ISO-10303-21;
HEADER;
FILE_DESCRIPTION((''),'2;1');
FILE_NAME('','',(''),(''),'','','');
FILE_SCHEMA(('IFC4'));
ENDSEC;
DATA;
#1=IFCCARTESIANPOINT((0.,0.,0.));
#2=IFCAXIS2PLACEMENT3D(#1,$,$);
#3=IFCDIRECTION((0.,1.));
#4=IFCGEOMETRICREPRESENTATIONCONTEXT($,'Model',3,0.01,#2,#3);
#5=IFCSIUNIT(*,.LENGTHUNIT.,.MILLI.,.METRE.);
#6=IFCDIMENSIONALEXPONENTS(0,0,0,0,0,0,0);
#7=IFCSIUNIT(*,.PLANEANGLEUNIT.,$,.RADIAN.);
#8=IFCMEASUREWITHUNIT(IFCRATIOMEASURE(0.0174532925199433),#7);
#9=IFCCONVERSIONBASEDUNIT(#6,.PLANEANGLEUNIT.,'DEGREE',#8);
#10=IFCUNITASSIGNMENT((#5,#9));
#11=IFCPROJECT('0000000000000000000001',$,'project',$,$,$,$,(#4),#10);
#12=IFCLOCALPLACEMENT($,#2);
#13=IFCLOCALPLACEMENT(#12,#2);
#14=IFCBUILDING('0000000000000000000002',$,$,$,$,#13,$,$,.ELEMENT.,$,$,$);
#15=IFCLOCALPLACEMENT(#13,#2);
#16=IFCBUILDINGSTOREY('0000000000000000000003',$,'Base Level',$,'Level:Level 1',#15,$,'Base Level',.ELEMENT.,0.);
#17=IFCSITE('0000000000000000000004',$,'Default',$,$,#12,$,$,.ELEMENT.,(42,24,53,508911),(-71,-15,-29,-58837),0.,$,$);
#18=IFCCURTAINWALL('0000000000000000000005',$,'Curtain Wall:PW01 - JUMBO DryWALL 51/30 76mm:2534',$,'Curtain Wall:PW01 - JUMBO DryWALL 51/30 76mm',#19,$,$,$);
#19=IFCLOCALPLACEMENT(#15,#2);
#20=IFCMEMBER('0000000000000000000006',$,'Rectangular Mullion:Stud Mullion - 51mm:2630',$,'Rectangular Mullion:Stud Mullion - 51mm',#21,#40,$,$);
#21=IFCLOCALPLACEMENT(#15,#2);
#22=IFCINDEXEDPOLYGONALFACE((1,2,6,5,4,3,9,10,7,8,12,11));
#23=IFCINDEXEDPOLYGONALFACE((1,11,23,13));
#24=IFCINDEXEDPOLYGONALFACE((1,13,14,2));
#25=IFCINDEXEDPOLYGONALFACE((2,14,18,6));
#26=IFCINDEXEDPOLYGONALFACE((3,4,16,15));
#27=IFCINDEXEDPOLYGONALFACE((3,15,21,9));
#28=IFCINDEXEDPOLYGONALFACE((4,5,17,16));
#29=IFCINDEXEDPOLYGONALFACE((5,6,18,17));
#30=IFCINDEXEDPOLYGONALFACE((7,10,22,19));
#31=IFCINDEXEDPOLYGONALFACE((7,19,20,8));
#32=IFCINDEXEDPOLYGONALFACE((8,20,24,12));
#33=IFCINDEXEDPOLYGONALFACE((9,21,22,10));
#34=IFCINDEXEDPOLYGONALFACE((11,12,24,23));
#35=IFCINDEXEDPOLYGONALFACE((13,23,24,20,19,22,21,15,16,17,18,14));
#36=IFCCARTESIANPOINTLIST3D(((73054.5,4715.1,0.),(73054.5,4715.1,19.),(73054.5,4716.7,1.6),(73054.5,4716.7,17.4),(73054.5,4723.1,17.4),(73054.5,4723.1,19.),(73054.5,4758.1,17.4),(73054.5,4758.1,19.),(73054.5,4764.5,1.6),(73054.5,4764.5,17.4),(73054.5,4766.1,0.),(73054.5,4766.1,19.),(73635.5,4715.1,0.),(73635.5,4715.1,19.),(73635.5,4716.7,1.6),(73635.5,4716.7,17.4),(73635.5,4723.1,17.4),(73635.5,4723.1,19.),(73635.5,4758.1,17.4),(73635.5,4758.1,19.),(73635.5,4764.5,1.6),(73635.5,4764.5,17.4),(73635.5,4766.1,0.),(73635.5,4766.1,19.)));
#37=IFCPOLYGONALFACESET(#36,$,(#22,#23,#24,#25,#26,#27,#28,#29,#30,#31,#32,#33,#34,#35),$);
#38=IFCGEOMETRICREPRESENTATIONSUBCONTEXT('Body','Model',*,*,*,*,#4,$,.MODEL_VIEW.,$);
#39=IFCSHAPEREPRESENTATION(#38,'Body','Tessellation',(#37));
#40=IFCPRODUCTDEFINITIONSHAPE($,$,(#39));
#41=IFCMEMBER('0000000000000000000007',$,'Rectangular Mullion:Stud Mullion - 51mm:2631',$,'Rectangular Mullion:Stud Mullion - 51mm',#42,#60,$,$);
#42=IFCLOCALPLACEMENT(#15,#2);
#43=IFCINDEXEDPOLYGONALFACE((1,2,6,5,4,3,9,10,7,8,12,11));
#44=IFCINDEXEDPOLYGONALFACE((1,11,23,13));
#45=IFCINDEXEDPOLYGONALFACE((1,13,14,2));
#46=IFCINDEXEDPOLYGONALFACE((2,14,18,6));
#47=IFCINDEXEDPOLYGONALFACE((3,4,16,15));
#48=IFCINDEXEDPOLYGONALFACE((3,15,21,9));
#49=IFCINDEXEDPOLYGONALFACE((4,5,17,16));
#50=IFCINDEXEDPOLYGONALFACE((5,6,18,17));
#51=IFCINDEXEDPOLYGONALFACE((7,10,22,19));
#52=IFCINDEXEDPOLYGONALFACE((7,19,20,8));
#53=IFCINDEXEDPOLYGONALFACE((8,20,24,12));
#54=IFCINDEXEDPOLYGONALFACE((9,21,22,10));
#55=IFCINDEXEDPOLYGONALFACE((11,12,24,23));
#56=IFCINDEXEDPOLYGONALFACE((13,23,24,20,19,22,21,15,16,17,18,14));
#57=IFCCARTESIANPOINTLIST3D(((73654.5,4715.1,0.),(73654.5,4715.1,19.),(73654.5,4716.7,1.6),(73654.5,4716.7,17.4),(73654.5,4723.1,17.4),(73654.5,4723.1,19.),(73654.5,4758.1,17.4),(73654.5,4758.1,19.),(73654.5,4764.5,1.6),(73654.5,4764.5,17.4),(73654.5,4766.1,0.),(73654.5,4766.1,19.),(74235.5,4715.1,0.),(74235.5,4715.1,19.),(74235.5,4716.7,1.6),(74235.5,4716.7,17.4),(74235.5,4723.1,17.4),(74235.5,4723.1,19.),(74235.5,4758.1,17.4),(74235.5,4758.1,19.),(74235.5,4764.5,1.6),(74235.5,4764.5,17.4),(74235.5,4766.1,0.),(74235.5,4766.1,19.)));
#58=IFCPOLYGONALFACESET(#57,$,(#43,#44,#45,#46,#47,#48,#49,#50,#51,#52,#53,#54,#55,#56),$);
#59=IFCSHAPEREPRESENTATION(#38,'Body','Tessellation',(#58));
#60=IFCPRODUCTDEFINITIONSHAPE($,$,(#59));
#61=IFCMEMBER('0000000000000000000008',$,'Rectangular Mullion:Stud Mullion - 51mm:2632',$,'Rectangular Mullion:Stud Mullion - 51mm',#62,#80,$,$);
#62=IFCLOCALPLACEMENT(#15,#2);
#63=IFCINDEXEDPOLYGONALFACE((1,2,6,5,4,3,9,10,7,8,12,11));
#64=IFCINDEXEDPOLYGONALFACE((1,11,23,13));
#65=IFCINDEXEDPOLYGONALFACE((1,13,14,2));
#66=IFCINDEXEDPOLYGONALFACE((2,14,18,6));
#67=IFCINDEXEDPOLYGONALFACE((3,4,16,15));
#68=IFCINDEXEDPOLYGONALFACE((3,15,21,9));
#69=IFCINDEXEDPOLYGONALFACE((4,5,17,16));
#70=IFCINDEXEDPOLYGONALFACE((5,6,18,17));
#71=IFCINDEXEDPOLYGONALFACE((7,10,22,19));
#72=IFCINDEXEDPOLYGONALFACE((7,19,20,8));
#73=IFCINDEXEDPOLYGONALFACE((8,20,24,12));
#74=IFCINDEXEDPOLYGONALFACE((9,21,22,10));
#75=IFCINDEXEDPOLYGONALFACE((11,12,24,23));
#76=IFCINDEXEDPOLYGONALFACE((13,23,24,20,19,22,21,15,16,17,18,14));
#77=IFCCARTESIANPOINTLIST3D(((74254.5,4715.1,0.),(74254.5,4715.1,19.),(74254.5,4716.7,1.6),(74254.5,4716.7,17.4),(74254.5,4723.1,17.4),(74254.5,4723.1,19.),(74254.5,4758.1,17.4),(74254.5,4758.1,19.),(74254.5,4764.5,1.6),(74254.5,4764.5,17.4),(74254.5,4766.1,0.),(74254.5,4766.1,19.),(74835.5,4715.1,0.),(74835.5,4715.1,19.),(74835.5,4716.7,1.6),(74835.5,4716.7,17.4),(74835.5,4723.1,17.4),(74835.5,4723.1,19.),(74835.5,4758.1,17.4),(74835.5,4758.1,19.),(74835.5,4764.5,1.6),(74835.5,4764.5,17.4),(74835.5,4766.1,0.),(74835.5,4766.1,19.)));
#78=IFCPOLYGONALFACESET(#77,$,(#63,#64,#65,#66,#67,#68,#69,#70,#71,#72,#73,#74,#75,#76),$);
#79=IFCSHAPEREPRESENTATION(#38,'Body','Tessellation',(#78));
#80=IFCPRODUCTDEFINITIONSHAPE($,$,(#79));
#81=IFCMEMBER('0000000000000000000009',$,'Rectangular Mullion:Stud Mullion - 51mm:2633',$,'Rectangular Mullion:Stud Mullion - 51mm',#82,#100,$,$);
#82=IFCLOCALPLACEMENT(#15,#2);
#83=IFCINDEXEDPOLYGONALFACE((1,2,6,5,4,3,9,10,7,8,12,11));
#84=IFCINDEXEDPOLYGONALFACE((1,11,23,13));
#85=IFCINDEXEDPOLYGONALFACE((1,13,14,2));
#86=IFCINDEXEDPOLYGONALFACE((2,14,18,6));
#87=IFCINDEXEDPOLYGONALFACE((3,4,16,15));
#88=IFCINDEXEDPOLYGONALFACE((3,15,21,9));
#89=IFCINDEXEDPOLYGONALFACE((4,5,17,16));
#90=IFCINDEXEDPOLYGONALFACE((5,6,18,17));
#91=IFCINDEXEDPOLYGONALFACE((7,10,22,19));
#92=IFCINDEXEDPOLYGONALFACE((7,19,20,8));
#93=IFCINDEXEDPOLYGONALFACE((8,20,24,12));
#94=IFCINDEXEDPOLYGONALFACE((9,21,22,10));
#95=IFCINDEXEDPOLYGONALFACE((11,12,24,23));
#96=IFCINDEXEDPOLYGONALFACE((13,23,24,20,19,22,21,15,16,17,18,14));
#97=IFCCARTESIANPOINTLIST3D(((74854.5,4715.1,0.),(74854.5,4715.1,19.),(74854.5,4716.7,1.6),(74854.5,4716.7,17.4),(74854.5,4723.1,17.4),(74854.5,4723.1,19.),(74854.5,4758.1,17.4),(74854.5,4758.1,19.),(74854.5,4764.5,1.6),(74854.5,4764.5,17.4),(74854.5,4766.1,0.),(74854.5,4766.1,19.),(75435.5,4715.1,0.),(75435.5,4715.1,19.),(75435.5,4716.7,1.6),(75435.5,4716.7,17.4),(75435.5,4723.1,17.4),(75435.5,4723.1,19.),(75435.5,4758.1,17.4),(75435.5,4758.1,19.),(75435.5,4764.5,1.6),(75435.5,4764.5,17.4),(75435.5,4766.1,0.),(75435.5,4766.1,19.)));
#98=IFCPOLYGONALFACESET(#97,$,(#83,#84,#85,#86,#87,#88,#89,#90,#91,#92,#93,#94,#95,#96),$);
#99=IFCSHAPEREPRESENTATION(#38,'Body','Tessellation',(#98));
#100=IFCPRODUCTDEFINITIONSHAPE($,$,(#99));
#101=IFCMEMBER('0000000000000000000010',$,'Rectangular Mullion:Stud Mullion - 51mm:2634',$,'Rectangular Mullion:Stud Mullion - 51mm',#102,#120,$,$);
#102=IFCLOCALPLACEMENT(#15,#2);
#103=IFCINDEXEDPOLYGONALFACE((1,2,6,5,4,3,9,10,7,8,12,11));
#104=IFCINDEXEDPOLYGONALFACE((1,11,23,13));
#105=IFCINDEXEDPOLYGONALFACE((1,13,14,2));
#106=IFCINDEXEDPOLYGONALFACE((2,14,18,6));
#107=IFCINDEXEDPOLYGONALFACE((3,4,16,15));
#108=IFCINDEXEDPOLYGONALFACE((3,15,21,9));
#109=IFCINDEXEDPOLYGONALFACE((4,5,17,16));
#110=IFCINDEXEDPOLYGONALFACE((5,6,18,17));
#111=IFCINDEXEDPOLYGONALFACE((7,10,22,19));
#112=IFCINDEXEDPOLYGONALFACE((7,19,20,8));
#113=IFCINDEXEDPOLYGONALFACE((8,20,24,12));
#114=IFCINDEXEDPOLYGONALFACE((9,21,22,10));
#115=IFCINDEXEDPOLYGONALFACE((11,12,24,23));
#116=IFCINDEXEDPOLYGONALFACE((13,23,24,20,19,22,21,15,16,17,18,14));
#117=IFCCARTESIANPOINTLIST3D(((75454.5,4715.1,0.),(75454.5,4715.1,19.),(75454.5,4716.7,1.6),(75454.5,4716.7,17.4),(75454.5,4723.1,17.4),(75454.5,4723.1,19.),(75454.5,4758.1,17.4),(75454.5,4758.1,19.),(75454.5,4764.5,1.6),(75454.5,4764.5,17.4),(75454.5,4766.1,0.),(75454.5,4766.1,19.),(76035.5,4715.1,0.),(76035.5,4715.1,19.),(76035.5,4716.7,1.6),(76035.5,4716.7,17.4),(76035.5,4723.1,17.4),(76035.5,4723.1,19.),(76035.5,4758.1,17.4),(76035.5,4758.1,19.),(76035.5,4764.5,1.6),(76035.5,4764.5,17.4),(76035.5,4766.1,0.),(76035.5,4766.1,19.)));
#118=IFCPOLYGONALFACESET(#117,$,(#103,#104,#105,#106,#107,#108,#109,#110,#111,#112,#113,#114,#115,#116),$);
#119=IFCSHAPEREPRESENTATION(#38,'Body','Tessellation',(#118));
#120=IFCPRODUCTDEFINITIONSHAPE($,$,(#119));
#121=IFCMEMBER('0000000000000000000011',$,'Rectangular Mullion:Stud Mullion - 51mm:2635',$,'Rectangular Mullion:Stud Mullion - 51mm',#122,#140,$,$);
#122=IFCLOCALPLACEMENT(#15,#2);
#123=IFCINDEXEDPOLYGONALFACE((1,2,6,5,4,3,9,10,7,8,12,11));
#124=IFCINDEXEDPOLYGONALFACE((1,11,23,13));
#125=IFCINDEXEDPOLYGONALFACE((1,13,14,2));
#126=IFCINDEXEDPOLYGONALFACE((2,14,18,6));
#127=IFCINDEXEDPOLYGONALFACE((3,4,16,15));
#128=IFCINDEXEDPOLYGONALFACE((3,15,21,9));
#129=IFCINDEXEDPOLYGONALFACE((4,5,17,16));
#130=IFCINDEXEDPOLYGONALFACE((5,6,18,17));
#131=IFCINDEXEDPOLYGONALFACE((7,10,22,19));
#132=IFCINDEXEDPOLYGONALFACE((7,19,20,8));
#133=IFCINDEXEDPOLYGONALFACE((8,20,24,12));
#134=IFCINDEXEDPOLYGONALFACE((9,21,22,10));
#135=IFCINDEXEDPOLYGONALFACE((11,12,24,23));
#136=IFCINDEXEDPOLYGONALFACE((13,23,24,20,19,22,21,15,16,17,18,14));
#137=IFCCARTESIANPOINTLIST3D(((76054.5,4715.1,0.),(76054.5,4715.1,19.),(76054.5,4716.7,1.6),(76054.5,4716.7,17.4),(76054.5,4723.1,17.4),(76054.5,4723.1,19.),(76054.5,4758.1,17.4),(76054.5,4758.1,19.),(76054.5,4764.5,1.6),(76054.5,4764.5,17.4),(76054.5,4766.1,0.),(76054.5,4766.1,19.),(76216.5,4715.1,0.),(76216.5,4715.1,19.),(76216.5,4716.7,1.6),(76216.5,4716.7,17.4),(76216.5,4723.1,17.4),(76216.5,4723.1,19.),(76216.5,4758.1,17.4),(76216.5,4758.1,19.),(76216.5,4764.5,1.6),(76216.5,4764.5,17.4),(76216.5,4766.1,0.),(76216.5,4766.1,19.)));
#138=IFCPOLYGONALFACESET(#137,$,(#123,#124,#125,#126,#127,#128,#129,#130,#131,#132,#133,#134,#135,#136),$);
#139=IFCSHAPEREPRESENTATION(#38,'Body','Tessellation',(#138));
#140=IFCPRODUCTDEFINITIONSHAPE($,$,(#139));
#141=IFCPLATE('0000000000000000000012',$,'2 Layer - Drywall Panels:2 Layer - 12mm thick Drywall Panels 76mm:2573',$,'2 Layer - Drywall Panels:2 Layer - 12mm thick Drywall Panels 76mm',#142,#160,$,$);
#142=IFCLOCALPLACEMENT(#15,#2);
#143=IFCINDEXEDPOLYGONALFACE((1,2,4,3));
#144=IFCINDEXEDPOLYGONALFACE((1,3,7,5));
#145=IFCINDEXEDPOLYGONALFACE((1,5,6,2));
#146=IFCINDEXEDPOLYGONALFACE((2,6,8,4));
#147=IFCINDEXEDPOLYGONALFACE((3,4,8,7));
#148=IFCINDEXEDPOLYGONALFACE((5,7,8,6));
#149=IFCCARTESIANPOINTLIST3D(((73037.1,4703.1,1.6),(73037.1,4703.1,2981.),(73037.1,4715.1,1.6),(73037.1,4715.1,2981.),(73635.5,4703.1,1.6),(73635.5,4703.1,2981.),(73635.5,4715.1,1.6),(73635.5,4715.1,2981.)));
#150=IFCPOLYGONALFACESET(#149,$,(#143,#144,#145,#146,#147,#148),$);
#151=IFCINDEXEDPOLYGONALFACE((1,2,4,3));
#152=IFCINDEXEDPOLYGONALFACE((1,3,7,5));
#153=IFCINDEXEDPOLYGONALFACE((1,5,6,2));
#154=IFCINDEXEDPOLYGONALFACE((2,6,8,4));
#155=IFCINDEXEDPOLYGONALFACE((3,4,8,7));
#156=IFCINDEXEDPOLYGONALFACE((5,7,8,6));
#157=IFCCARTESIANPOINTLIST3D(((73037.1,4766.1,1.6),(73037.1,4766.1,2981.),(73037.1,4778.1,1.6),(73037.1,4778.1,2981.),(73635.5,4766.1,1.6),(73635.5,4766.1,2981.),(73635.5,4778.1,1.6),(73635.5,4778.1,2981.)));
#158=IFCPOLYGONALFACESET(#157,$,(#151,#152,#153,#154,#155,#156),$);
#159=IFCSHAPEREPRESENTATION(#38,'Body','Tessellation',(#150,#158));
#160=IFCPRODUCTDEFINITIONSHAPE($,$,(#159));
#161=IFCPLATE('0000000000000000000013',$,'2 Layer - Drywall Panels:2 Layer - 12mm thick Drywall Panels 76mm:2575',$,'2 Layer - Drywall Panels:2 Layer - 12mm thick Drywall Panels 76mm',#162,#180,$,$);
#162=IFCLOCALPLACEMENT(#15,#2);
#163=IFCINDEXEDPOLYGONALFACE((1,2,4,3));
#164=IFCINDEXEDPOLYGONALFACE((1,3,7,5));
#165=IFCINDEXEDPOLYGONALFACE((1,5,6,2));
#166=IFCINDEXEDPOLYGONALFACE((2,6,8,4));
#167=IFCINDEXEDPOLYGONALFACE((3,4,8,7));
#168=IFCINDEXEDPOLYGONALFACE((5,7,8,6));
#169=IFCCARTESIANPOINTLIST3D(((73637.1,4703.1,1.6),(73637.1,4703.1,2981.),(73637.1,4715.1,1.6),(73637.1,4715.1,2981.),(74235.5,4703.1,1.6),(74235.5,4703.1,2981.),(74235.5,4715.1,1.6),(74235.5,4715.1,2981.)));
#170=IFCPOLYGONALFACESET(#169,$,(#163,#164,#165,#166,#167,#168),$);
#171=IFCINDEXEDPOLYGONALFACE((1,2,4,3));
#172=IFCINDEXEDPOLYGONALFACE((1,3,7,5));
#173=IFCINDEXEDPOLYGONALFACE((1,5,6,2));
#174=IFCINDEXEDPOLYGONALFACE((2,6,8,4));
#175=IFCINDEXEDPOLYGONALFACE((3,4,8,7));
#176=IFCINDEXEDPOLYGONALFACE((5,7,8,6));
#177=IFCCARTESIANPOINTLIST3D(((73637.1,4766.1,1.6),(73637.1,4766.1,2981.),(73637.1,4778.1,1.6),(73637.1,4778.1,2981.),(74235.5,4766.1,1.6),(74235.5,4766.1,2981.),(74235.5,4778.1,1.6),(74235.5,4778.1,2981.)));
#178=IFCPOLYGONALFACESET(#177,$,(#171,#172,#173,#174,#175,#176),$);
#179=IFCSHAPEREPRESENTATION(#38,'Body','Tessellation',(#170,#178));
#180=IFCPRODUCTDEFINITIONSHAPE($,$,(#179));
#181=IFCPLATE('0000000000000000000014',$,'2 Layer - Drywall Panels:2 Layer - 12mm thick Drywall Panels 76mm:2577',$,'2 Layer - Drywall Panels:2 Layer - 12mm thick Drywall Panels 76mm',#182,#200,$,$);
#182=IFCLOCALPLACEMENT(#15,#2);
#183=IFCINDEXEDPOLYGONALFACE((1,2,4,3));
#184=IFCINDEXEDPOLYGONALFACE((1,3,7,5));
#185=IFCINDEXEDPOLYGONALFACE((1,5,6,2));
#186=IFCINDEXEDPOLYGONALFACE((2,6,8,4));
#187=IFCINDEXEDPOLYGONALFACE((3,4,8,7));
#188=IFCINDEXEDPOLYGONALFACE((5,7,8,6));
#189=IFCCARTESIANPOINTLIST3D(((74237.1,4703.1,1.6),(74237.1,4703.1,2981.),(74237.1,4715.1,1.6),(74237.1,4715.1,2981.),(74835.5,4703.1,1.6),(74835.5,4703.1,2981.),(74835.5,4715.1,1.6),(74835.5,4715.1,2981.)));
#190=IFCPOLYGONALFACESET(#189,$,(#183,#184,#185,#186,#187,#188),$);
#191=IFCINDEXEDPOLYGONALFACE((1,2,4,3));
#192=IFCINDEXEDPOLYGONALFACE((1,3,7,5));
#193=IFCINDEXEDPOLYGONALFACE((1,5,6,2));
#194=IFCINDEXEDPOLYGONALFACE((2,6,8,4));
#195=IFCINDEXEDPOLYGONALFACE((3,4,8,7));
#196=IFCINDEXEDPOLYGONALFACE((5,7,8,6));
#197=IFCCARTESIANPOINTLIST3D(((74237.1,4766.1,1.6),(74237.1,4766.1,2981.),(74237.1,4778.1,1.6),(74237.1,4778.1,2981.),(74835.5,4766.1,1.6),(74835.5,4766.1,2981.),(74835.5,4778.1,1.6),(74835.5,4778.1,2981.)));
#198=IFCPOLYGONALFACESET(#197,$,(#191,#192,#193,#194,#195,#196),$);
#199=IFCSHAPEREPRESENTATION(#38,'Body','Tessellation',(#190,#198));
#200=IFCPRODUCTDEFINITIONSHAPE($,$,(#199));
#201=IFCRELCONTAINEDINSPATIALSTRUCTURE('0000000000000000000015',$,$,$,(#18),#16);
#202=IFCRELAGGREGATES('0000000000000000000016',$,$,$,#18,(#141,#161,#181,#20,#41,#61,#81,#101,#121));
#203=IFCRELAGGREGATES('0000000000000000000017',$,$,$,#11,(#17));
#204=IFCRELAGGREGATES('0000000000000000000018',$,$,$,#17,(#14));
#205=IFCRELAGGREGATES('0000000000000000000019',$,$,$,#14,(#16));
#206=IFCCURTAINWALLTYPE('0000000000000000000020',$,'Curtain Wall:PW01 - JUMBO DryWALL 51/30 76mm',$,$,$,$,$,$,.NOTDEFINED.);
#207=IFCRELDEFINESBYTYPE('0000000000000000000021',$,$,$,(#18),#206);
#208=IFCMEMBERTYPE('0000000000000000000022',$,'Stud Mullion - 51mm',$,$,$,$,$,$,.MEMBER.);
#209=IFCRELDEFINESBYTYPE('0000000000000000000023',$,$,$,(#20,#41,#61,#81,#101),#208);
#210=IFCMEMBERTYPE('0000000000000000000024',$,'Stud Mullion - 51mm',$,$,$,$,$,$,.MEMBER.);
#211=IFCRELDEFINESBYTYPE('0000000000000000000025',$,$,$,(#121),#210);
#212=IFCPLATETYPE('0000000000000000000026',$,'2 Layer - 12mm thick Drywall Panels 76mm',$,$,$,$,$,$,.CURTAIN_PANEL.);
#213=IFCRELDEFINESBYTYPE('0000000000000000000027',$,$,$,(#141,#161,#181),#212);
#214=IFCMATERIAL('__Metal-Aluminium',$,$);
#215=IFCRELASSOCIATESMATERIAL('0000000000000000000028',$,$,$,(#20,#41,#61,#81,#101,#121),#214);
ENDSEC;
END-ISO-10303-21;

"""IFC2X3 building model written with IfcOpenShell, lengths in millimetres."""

from ifc_helpers import new_model, entity, si_unit, converted_unit, direction, frame, frame_2d, origin, origin_2d_with_axis, place, context, subcontext, project, spatial, polyline, rectangle, outline, extrude, source, transform, mapped, material, type_object, type_shapes, element, aggregate, save


model = new_model("IFC2X3")

# Units and contexts
model_context = context("Model", 3, precision=0.01, world=origin(), true_north=direction((0.0, 1.0)))
body_context = subcontext(model_context, "Body", "Model", "MODEL_VIEW")
ifc_project = project(units=[si_unit("LENGTHUNIT", "METRE", prefix="MILLI"), converted_unit("PLANEANGLEUNIT", "DEGREE", entity("IfcRatioMeasure", 0.0174532925199433), si_unit("PLANEANGLEUNIT", "RADIAN"), dimensions=[0, 0, 0, 0, 0, 0, 0])], contexts=[model_context])

# Site, building, storey
site_placement = place(None, origin())
site = spatial("IfcSite", under=ifc_project, at=site_placement, Name="Default", CompositionType="ELEMENT", RefLatitude=(42, 24, 53, 508911), RefLongitude=(-71, -15, -29, -58837), RefElevation=0.0)
building_placement = place(site_placement, origin())
building = spatial("IfcBuilding", under=site, at=building_placement, CompositionType="ELEMENT")
storey_placement = place(building_placement, origin())
storey = spatial("IfcBuildingStorey", under=building, at=storey_placement, Name="Base Level", ObjectType="Level:Level 1", LongName="Base Level", CompositionType="ELEMENT", Elevation=0.0)

# Curtain wall, members, plates
curtain_wall_type = type_object("IfcCurtainWallType", Name="Curtain Wall:PW01 - JUMBO DryWALL 51/30 76mm", PredefinedType="NOTDEFINED")
curtain_wall_placement = place(building_placement, origin())
curtain_wall = element("IfcCurtainWall", 1, at=curtain_wall_placement, inside=storey, type_object=curtain_wall_type, Name="Curtain Wall:PW01 - JUMBO DryWALL 51/30 76mm:2534", ObjectType="Curtain Wall:PW01 - JUMBO DryWALL 51/30 76mm")
ifc_material = material(Name="__Metal-Aluminium")
member_type_1 = type_object("IfcMemberType", Name="Stud Mullion - 51mm", PredefinedType="MEMBER")
shared_shape_1 = source(origin(), body_context, "Body", "SweptSolid", [
    extrude(outline(polyline([(17.5, -6.6), (25.5, -6.6), (25.5, 12.4), (-25.5, 12.4), (-25.5, -6.6), (-17.5, -6.6), (-17.5, -5.0), (-23.9, -5.0), (-23.9, 10.8), (23.9, 10.8), (23.9, -5.0), (17.5, -5.0), (17.5, -6.6)])), frame((-12.4, 0.0, -581.0), z_axis=(0.0, 0.0, 1.0), x_axis=(0.0, -1.0, 0.0)), (0.0, 0.0, 1.0), 581.0),
])
type_shapes(member_type_1, [shared_shape_1])
member_1_placement = place(building_placement, frame((73054.5, 4740.6, 0.0), z_axis=(-1.0, 0.0, 0.0), x_axis=(0.0, 0.0, -1.0)))
member_1 = element("IfcMember", 2, at=member_1_placement, type_object=member_type_1, material=ifc_material, Name="Rectangular Mullion:Stud Mullion - 51mm:2630", ObjectType="Rectangular Mullion:Stud Mullion - 51mm", context=body_context, shape_type="MappedRepresentation", body=[
    mapped(shared_shape_1, transform((0.0, 0.0, 0.0), scale=1.0)),
])
member_2_placement = place(building_placement, frame((73654.5, 4740.6, 0.0), z_axis=(-1.0, 0.0, 0.0), x_axis=(0.0, 0.0, -1.0)))
member_2 = element("IfcMember", 3, at=member_2_placement, type_object=member_type_1, material=ifc_material, Name="Rectangular Mullion:Stud Mullion - 51mm:2631", ObjectType="Rectangular Mullion:Stud Mullion - 51mm", context=body_context, shape_type="MappedRepresentation", body=[
    mapped(shared_shape_1, transform((0.0, 0.0, 0.0), scale=1.0)),
])
member_3_placement = place(building_placement, frame((74254.5, 4740.6, 0.0), z_axis=(-1.0, 0.0, 0.0), x_axis=(0.0, 0.0, -1.0)))
member_3 = element("IfcMember", 4, at=member_3_placement, type_object=member_type_1, material=ifc_material, Name="Rectangular Mullion:Stud Mullion - 51mm:2632", ObjectType="Rectangular Mullion:Stud Mullion - 51mm", context=body_context, shape_type="MappedRepresentation", body=[
    mapped(shared_shape_1, transform((0.0, 0.0, 0.0), scale=1.0)),
])
member_4_placement = place(building_placement, frame((74854.5, 4740.6, 0.0), z_axis=(-1.0, 0.0, 0.0), x_axis=(0.0, 0.0, -1.0)))
member_4 = element("IfcMember", 5, at=member_4_placement, type_object=member_type_1, material=ifc_material, Name="Rectangular Mullion:Stud Mullion - 51mm:2633", ObjectType="Rectangular Mullion:Stud Mullion - 51mm", context=body_context, shape_type="MappedRepresentation", body=[
    mapped(shared_shape_1, transform((0.0, 0.0, 0.0), scale=1.0)),
])
member_5_placement = place(building_placement, frame((75454.5, 4740.6, 0.0), z_axis=(-1.0, 0.0, 0.0), x_axis=(0.0, 0.0, -1.0)))
member_5 = element("IfcMember", 6, at=member_5_placement, type_object=member_type_1, material=ifc_material, Name="Rectangular Mullion:Stud Mullion - 51mm:2634", ObjectType="Rectangular Mullion:Stud Mullion - 51mm", context=body_context, shape_type="MappedRepresentation", body=[
    mapped(shared_shape_1, transform((0.0, 0.0, 0.0), scale=1.0)),
])
member_type_2 = type_object("IfcMemberType", Name="Stud Mullion - 51mm", PredefinedType="MEMBER")
shared_shape_2 = source(origin(), body_context, "Body", "SweptSolid", [
    extrude(outline(polyline([(17.5, -6.6), (25.5, -6.6), (25.5, 12.4), (-25.5, 12.4), (-25.5, -6.6), (-17.5, -6.6), (-17.5, -5.0), (-23.9, -5.0), (-23.9, 10.8), (23.9, 10.8), (23.9, -5.0), (17.5, -5.0), (17.5, -6.6)])), frame((-12.4, 0.0, -162.0), z_axis=(0.0, 0.0, 1.0), x_axis=(0.0, -1.0, 0.0)), (0.0, 0.0, 1.0), 162.0),
])
type_shapes(member_type_2, [shared_shape_2])
member_6_placement = place(building_placement, frame((76054.5, 4740.6, 0.0), z_axis=(-1.0, 0.0, 0.0), x_axis=(0.0, 0.0, -1.0)))
member_6 = element("IfcMember", 7, at=member_6_placement, type_object=member_type_2, material=ifc_material, Name="Rectangular Mullion:Stud Mullion - 51mm:2635", ObjectType="Rectangular Mullion:Stud Mullion - 51mm", context=body_context, shape_type="MappedRepresentation", body=[
    mapped(shared_shape_2, transform((0.0, 0.0, 0.0), scale=1.0)),
])
plate_type_1 = type_object("IfcPlateType", Name="2 Layer - 12mm thick Drywall Panels 76mm", PredefinedType="CURTAIN_PANEL")
shared_shape_3 = source(origin(), body_context, "Body", "SweptSolid", [
    extrude(rectangle(XDim=598.4, YDim=12.0, at=origin_2d_with_axis()), frame((0.0, -31.5, 0.0), z_axis=(0.0, 0.0, 1.0), x_axis=(-1.0, 0.0, 0.0)), (0.0, 0.0, 1.0), 2979.4),
    extrude(rectangle(XDim=12.0, YDim=598.4, at=frame_2d((0.0, 0.0), x_axis=(1.0, 0.0))), frame((0.0, 31.5, 0.0), z_axis=(0.0, 0.0, 1.0), x_axis=(0.0, 1.0, 0.0)), (0.0, 0.0, 1.0), 2979.4),
])
type_shapes(plate_type_1, [shared_shape_3])
plate_1_placement = place(curtain_wall_placement, frame((73336.3, 4740.6, 1.6)))
plate_1 = element("IfcPlate", 8, at=plate_1_placement, type_object=plate_type_1, Name="2 Layer - Drywall Panels:2 Layer - 12mm thick Drywall Panels 76mm:2573", ObjectType="2 Layer - Drywall Panels:2 Layer - 12mm thick Drywall Panels 76mm", context=body_context, shape_type="MappedRepresentation", body=[
    mapped(shared_shape_3, transform((0.0, 0.0, 0.0), scale=1.0)),
])
plate_2_placement = place(curtain_wall_placement, frame((73936.3, 4740.6, 1.6)))
plate_2 = element("IfcPlate", 9, at=plate_2_placement, type_object=plate_type_1, Name="2 Layer - Drywall Panels:2 Layer - 12mm thick Drywall Panels 76mm:2575", ObjectType="2 Layer - Drywall Panels:2 Layer - 12mm thick Drywall Panels 76mm", context=body_context, shape_type="MappedRepresentation", body=[
    mapped(shared_shape_3, transform((0.0, 0.0, 0.0), scale=1.0)),
])
plate_3_placement = place(curtain_wall_placement, frame((74536.3, 4740.6, 1.6)))
plate_3 = element("IfcPlate", 10, at=plate_3_placement, type_object=plate_type_1, Name="2 Layer - Drywall Panels:2 Layer - 12mm thick Drywall Panels 76mm:2577", ObjectType="2 Layer - Drywall Panels:2 Layer - 12mm thick Drywall Panels 76mm", context=body_context, shape_type="MappedRepresentation", body=[
    mapped(shared_shape_3, transform((0.0, 0.0, 0.0), scale=1.0)),
])
aggregate(curtain_wall, [plate_1, plate_2, plate_3, member_1, member_2, member_3, member_4, member_5, member_6])

save(model, "model.ifc")
